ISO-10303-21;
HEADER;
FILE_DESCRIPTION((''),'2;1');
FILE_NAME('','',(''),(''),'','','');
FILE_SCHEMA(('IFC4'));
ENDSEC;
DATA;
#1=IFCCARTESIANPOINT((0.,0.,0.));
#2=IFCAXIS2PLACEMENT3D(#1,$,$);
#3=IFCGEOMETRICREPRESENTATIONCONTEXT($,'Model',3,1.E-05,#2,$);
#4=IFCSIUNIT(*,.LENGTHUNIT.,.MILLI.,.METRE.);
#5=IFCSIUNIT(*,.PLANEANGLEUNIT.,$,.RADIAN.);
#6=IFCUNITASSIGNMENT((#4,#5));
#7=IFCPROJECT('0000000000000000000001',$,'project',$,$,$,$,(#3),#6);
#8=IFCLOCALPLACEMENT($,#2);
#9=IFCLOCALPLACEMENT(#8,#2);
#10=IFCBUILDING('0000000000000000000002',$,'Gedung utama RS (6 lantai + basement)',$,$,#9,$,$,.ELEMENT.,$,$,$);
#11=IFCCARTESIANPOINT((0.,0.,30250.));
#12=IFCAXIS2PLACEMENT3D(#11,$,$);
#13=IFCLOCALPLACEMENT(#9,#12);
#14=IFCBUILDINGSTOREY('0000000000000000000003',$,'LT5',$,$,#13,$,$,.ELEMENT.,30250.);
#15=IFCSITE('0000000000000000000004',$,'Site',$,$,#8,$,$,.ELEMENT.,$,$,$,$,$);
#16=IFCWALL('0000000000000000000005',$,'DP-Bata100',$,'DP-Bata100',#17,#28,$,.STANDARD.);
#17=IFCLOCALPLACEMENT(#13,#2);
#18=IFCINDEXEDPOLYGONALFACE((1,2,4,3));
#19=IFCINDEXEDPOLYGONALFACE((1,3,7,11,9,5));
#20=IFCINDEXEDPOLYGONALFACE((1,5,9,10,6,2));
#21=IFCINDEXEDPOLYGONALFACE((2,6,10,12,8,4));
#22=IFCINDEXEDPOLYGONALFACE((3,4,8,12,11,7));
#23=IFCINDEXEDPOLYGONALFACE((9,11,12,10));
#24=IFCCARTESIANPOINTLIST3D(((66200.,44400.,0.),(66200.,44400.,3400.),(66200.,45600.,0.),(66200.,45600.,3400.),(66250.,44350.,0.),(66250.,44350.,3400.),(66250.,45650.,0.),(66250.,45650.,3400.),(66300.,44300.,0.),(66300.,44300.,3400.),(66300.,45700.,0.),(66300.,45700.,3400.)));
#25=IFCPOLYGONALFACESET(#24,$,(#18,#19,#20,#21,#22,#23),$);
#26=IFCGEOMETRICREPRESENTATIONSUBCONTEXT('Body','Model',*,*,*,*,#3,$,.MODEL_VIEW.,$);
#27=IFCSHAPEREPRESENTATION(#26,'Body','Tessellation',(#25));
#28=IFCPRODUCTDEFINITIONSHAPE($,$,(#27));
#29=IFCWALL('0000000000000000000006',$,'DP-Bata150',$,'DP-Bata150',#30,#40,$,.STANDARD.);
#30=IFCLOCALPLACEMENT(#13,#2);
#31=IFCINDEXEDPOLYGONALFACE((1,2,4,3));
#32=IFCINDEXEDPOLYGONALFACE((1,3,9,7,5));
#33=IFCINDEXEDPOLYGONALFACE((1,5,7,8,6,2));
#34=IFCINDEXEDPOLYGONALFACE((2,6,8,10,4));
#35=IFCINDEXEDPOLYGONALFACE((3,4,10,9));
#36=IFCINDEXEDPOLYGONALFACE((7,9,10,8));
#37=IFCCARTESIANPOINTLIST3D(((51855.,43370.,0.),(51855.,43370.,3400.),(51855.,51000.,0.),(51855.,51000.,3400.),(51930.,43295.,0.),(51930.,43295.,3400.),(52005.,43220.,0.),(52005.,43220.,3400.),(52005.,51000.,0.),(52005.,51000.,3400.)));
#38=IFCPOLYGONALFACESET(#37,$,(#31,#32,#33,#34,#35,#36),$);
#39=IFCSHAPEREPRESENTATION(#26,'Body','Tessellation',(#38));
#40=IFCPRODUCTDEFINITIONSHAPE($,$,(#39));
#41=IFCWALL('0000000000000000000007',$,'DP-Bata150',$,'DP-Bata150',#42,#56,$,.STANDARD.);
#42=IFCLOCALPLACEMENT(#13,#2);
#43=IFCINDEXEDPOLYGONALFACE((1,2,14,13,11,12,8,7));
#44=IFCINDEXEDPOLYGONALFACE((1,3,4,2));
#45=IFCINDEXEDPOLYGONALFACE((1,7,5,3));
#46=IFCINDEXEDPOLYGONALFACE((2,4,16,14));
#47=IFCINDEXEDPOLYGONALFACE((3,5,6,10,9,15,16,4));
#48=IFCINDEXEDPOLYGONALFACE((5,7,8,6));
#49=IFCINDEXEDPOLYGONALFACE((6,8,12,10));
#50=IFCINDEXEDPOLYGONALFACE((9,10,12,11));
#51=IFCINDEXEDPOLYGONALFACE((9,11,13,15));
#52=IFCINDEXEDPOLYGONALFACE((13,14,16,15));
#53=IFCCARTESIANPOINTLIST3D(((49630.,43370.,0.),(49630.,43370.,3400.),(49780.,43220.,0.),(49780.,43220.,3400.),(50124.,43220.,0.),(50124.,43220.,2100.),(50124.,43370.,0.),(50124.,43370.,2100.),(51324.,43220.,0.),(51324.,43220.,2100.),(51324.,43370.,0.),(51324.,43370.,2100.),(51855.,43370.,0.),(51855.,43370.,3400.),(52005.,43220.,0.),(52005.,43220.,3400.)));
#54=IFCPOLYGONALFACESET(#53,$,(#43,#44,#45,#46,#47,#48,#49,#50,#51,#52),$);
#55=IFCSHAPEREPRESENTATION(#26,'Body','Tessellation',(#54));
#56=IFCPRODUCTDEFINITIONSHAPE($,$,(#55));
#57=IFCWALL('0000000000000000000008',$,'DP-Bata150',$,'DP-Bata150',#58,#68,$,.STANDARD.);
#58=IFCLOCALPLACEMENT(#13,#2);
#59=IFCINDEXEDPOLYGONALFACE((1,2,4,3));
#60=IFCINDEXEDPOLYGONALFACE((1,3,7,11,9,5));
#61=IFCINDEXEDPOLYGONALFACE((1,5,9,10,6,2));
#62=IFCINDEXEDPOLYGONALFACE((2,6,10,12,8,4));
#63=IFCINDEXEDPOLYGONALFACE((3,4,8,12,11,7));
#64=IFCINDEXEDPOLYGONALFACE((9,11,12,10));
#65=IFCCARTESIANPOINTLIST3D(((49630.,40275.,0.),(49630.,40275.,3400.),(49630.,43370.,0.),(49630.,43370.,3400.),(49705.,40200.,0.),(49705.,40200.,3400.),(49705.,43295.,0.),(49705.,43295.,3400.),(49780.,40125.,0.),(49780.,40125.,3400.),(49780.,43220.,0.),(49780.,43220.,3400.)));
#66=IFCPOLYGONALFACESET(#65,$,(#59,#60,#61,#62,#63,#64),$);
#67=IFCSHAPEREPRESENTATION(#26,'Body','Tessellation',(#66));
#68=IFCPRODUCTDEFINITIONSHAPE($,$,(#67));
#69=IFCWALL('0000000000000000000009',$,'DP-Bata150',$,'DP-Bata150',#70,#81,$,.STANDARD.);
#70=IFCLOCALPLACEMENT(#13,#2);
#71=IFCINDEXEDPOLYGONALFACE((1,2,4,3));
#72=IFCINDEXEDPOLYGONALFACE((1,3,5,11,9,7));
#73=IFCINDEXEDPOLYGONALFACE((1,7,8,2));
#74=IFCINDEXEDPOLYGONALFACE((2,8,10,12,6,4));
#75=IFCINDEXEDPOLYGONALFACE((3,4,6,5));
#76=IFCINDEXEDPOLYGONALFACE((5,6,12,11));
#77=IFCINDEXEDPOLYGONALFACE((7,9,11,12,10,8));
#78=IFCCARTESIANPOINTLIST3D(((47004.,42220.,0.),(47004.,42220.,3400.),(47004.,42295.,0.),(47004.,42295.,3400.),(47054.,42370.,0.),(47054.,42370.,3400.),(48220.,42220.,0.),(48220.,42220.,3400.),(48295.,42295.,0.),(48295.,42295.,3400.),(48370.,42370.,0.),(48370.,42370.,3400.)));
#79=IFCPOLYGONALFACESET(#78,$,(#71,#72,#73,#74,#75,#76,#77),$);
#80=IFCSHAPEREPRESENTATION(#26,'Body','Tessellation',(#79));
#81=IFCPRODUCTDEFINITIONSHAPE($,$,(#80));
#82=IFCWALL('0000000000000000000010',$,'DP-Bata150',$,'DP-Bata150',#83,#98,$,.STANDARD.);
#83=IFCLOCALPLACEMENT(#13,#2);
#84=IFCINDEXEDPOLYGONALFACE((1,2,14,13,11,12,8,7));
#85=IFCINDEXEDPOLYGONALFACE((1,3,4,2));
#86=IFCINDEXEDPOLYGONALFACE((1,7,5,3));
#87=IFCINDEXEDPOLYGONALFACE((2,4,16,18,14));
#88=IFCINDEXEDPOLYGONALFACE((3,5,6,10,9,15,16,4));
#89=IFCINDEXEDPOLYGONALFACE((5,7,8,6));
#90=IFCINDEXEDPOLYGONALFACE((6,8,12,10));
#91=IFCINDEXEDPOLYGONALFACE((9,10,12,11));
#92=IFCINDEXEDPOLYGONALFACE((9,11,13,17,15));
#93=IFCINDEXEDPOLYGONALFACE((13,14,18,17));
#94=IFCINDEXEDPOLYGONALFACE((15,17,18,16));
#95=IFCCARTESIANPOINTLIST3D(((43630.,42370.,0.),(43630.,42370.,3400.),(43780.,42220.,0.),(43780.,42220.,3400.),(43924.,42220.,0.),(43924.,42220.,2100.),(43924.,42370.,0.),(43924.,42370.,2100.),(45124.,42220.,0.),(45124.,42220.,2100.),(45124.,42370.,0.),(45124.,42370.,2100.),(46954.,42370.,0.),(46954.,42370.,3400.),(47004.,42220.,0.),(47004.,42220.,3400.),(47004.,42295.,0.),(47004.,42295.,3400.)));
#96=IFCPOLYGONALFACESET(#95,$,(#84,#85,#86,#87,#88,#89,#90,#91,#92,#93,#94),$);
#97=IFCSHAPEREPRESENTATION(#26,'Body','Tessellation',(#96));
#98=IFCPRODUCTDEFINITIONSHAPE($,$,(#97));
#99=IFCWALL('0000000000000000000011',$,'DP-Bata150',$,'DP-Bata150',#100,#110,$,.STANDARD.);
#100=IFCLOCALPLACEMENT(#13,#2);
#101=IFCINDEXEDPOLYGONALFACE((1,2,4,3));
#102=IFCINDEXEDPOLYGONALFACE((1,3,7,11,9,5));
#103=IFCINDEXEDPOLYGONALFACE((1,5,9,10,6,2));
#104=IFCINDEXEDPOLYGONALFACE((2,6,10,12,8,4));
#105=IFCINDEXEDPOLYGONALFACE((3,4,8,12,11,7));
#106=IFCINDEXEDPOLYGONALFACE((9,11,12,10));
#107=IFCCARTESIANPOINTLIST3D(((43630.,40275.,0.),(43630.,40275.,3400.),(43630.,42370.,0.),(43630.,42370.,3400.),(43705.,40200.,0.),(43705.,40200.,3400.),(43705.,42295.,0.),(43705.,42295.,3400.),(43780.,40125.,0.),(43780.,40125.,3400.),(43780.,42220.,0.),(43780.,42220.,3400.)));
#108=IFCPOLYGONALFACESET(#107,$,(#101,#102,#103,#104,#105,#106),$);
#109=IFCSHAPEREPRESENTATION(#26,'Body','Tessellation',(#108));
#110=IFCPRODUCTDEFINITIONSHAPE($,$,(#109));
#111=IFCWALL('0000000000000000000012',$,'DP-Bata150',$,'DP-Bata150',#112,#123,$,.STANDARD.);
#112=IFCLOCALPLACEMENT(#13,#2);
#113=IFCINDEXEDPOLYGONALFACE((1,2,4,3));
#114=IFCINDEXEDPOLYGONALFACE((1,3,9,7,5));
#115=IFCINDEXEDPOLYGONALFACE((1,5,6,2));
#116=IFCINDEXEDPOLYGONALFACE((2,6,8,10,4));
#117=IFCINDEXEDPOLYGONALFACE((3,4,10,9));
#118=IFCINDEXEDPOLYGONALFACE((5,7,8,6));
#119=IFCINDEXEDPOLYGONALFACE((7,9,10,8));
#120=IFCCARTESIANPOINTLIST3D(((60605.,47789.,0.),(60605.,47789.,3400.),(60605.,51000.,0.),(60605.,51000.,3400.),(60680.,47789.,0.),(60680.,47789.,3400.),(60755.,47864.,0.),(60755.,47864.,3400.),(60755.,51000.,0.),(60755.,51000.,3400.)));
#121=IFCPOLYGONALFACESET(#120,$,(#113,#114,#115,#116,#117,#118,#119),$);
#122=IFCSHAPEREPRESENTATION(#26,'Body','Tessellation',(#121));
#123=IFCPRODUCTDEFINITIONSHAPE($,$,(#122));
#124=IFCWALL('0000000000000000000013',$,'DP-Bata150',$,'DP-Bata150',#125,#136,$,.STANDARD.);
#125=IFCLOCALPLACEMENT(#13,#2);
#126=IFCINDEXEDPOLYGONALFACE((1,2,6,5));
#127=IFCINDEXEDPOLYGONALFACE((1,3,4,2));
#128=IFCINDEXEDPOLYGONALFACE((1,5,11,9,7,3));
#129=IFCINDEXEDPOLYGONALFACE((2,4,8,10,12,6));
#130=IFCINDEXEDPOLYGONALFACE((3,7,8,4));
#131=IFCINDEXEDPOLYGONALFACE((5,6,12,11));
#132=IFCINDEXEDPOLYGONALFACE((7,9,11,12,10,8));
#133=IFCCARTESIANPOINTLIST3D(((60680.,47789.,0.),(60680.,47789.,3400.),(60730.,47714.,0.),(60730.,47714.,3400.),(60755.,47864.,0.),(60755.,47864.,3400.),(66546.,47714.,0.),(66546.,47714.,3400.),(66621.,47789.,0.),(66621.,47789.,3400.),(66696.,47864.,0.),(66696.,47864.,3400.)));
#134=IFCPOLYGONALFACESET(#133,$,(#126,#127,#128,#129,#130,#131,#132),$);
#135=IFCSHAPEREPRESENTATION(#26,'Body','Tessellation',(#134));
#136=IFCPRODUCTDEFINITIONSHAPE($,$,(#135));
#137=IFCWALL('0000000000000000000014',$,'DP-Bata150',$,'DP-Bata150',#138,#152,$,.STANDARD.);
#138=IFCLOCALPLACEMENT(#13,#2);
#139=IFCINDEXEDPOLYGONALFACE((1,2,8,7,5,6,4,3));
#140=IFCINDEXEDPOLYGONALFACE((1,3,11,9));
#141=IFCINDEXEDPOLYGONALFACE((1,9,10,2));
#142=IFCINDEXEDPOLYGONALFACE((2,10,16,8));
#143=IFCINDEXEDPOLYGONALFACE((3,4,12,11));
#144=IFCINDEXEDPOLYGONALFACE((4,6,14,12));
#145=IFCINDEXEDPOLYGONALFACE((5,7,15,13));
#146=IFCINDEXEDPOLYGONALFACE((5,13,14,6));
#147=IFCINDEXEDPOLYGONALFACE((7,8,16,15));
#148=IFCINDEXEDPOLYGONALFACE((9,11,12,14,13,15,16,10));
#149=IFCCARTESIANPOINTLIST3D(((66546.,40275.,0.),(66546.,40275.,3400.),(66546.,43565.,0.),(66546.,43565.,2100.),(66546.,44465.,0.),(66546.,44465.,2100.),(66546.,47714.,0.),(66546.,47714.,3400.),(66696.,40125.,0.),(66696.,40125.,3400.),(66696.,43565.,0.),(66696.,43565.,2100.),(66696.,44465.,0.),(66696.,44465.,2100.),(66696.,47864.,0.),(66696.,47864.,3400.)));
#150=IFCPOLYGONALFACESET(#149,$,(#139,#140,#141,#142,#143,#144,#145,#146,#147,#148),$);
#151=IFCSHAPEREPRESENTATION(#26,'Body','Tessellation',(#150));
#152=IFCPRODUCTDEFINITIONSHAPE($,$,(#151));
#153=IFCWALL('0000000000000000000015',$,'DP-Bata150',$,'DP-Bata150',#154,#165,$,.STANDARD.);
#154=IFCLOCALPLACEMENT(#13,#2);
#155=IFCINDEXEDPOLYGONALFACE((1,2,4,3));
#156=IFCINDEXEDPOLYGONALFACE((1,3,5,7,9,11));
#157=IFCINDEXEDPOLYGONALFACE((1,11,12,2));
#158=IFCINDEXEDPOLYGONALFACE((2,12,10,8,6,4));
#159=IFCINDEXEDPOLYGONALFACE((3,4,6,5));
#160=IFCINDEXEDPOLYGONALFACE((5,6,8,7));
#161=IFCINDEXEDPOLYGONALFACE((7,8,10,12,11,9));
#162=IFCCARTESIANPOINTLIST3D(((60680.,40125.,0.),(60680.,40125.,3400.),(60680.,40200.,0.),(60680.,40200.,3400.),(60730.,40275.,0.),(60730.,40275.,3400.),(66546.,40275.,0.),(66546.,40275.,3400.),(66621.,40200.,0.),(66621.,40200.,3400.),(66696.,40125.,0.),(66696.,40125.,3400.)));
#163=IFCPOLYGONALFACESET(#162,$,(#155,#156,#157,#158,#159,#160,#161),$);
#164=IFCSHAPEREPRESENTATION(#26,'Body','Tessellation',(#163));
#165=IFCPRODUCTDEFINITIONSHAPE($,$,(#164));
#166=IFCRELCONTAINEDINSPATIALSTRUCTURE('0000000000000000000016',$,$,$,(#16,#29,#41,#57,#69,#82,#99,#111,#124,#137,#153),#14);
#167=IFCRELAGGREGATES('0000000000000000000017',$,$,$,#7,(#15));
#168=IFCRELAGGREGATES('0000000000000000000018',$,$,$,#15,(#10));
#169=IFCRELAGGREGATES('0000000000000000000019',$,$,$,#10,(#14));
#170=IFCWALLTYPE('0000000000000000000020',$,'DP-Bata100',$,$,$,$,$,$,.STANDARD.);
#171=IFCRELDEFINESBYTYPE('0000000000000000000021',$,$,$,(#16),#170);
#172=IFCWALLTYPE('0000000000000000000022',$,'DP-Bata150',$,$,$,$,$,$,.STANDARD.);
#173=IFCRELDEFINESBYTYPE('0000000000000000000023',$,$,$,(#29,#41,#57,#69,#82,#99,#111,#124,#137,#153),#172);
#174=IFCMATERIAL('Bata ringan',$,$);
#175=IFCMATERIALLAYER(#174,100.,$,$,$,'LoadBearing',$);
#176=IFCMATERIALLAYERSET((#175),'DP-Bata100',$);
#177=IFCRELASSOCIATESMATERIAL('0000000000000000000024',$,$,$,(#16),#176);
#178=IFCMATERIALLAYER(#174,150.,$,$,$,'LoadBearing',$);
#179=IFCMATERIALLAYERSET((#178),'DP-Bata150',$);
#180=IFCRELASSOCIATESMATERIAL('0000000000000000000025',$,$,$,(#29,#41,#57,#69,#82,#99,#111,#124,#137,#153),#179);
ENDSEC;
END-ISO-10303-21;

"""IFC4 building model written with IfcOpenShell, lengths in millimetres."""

from ifc_helpers import new_model, si_unit, frame, frame_2d, origin, place, context, subcontext, project, spatial, polyline, rectangle, outline, extrude, material, layer, layer_set, layer_usage, type_object, element, save


model = new_model("IFC4")

# Units and contexts
model_context = context("Model", 3, precision=1e-05, world=origin())
body_context = subcontext(model_context, "Body", "Model", "MODEL_VIEW")
ifc_project = project(units=[si_unit("LENGTHUNIT", "METRE", prefix="MILLI"), si_unit("PLANEANGLEUNIT", "RADIAN")], contexts=[model_context])

# Site, building, storey
site_placement = place(None, origin())
site = spatial("IfcSite", under=ifc_project, at=site_placement, Name="Site", CompositionType="ELEMENT")
building_placement = place(site_placement, origin())
building = spatial("IfcBuilding", under=site, at=building_placement, Name="Gedung utama RS (6 lantai + basement)", CompositionType="ELEMENT")
storey_placement = place(building_placement, frame((0.0, 0.0, 30250.0)))
storey = spatial("IfcBuildingStorey", under=building, at=storey_placement, Name="LT5", CompositionType="ELEMENT", Elevation=30250.0)

# Walls
ifc_material_1 = material(Name="Bata ringan")
ifc_layer_1 = layer(ifc_material_1, 100.0, Category="LoadBearing")
ifc_layer_set_1 = layer_set([ifc_layer_1], Name="DP-Bata100")
ifc_layer_usage_1 = layer_usage(ifc_layer_set_1, "AXIS2", "NEGATIVE", 50.0)
wall_type_1 = type_object("IfcWallType", Name="DP-Bata100", PredefinedType="STANDARD")
wall_1_placement = place(storey_placement, frame((66250.0, 45650.0, 0.0), z_axis=(0.0, 0.0, 1.0), x_axis=(0.0, -1.0, 0.0)))
element("IfcWall", 1, at=wall_1_placement, inside=storey, type_object=wall_type_1, material=ifc_layer_usage_1, Name="DP-Bata100", ObjectType="DP-Bata100", PredefinedType="STANDARD", context=body_context, shape_type="SweptSolid", body=[
    extrude(outline(polyline([(50.0, -50.0), (0.0, 0.0), (-50.0, 50.0), (1350.0, 50.0), (1300.0, 0.0), (1250.0, -50.0), (50.0, -50.0)])), origin(), (0.0, 0.0, 1.0), 3400.0),
])
ifc_layer_2 = layer(ifc_material_1, 150.0, Category="LoadBearing")
ifc_layer_set_2 = layer_set([ifc_layer_2], Name="DP-Bata150")
ifc_layer_usage_2 = layer_usage(ifc_layer_set_2, "AXIS2", "NEGATIVE", 75.0)
wall_type_2 = type_object("IfcWallType", Name="DP-Bata150", PredefinedType="STANDARD")
wall_2_placement = place(storey_placement, frame((51930.0, 51000.0, 0.0), z_axis=(0.0, 0.0, 1.0), x_axis=(0.0, -1.0, 0.0)))
element("IfcWall", 2, at=wall_2_placement, inside=storey, type_object=wall_type_2, material=ifc_layer_usage_2, Name="DP-Bata150", ObjectType="DP-Bata150", PredefinedType="STANDARD", context=body_context, shape_type="SweptSolid", body=[
    extrude(outline(polyline([(0.0, -75.0), (0.0, 75.0), (7780.0, 75.0), (7705.0, 0.0), (7630.0, -75.0), (0.0, -75.0)])), origin(), (0.0, 0.0, 1.0), 3400.0),
])

# Wall, opening
wall_3_placement = place(storey_placement, frame((51930.0, 43295.0, 0.0), z_axis=(0.0, 0.0, 1.0), x_axis=(-1.0, 0.0, 0.0)))
wall_3 = element("IfcWall", 3, at=wall_3_placement, inside=storey, type_object=wall_type_2, material=ifc_layer_usage_2, Name="DP-Bata150", ObjectType="DP-Bata150", PredefinedType="STANDARD", context=body_context, shape_type="SweptSolid", body=[
    extrude(outline(polyline([(75.0, -75.0), (0.0, 0.0), (-75.0, 75.0), (2150.0, 75.0), (2225.0, 0.0), (2300.0, -75.0), (75.0, -75.0)])), origin(), (0.0, 0.0, 1.0), 3400.0),
])
opening_1_placement = place(wall_3_placement, frame((606.0, 0.0, 0.0), z_axis=(0.0, 0.0, 1.0), x_axis=(1.0, 0.0, 0.0)))
element("IfcOpeningElement", 4, at=opening_1_placement, cuts=wall_3, PredefinedType="OPENING", context=body_context, shape_type="SweptSolid", body=[
    extrude(rectangle(XDim=1200.0, YDim=170.0, at=frame_2d((600.0, 0.0))), origin(), (0.0, 0.0, 1.0), 2100.0),
])

# Walls
wall_4_placement = place(storey_placement, frame((49705.0, 43295.0, 0.0), z_axis=(0.0, 0.0, 1.0), x_axis=(0.0, -1.0, 0.0)))
element("IfcWall", 5, at=wall_4_placement, inside=storey, type_object=wall_type_2, material=ifc_layer_usage_2, Name="DP-Bata150", ObjectType="DP-Bata150", PredefinedType="STANDARD", context=body_context, shape_type="SweptSolid", body=[
    extrude(outline(polyline([(-75.0, -75.0), (0.0, 0.0), (75.0, 75.0), (3170.0, 75.0), (3095.0, 0.0), (3020.0, -75.0), (-75.0, -75.0)])), origin(), (0.0, 0.0, 1.0), 3400.0),
])
wall_5_placement = place(storey_placement, frame((48295.0, 42295.0, 0.0), z_axis=(0.0, 0.0, 1.0), x_axis=(-1.0, 0.0, 0.0)))
element("IfcWall", 6, at=wall_5_placement, inside=storey, type_object=wall_type_2, material=ifc_layer_usage_2, Name="DP-Bata150", ObjectType="DP-Bata150", PredefinedType="STANDARD", context=body_context, shape_type="SweptSolid", body=[
    extrude(outline(polyline([(-75.0, -75.0), (0.0, 0.0), (75.0, 75.0), (1291.0, 75.0), (1291.0, 0.0), (1241.0, -75.0), (-75.0, -75.0)])), origin(), (0.0, 0.0, 1.0), 3400.0),
])

# Wall, opening
wall_6_placement = place(storey_placement, frame((47004.0, 42295.0, 0.0), z_axis=(0.0, 0.0, 1.0), x_axis=(-1.0, 0.0, 0.0)))
wall_6 = element("IfcWall", 7, at=wall_6_placement, inside=storey, type_object=wall_type_2, material=ifc_layer_usage_2, Name="DP-Bata150", ObjectType="DP-Bata150", PredefinedType="STANDARD", context=body_context, shape_type="SweptSolid", body=[
    extrude(outline(polyline([(50.0, -75.0), (0.0, 0.0), (0.0, 75.0), (3224.0, 75.0), (3299.0, 0.0), (3374.0, -75.0), (50.0, -75.0)])), origin(), (0.0, 0.0, 1.0), 3400.0),
])
opening_2_placement = place(wall_6_placement, frame((1880.0, 0.0, 0.0), z_axis=(0.0, 0.0, 1.0), x_axis=(1.0, 0.0, 0.0)))
element("IfcOpeningElement", 8, at=opening_2_placement, cuts=wall_6, PredefinedType="OPENING", context=body_context, shape_type="SweptSolid", body=[
    extrude(rectangle(XDim=1200.0, YDim=170.0, at=frame_2d((600.0, 0.0))), origin(), (0.0, 0.0, 1.0), 2100.0),
])

# Walls
wall_7_placement = place(storey_placement, frame((43705.0, 42295.0, 0.0), z_axis=(0.0, 0.0, 1.0), x_axis=(0.0, -1.0, 0.0)))
element("IfcWall", 9, at=wall_7_placement, inside=storey, type_object=wall_type_2, material=ifc_layer_usage_2, Name="DP-Bata150", ObjectType="DP-Bata150", PredefinedType="STANDARD", context=body_context, shape_type="SweptSolid", body=[
    extrude(outline(polyline([(-75.0, -75.0), (0.0, 0.0), (75.0, 75.0), (2170.0, 75.0), (2095.0, 0.0), (2020.0, -75.0), (-75.0, -75.0)])), origin(), (0.0, 0.0, 1.0), 3400.0),
])
wall_8_placement = place(storey_placement, frame((60680.0, 51000.0, 0.0), z_axis=(0.0, 0.0, 1.0), x_axis=(0.0, -1.0, 0.0)))
element("IfcWall", 10, at=wall_8_placement, inside=storey, type_object=wall_type_2, material=ifc_layer_usage_2, Name="DP-Bata150", ObjectType="DP-Bata150", PredefinedType="STANDARD", context=body_context, shape_type="SweptSolid", body=[
    extrude(outline(polyline([(0.0, -75.0), (0.0, 75.0), (3136.0, 75.0), (3211.0, 0.0), (3211.0, -75.0), (0.0, -75.0)])), origin(), (0.0, 0.0, 1.0), 3400.0),
])
wall_9_placement = place(storey_placement, frame((60680.0, 47789.0, 0.0), z_axis=(0.0, 0.0, 1.0), x_axis=(1.0, 0.0, 0.0)))
element("IfcWall", 11, at=wall_9_placement, inside=storey, type_object=wall_type_2, material=ifc_layer_usage_2, Name="DP-Bata150", ObjectType="DP-Bata150", PredefinedType="STANDARD", context=body_context, shape_type="SweptSolid", body=[
    extrude(outline(polyline([(50.0, -75.0), (0.0, 0.0), (75.0, 75.0), (6016.0, 75.0), (5941.0, 0.0), (5866.0, -75.0), (50.0, -75.0)])), origin(), (0.0, 0.0, 1.0), 3400.0),
])

# Wall, opening
wall_10_placement = place(storey_placement, frame((66621.0, 47789.0, 0.0), z_axis=(0.0, 0.0, 1.0), x_axis=(0.0, -1.0, 0.0)))
wall_10 = element("IfcWall", 12, at=wall_10_placement, inside=storey, type_object=wall_type_2, material=ifc_layer_usage_2, Name="DP-Bata150", ObjectType="DP-Bata150", PredefinedType="STANDARD", context=body_context, shape_type="SweptSolid", body=[
    extrude(outline(polyline([(75.0, -75.0), (0.0, 0.0), (-75.0, 75.0), (7664.0, 75.0), (7589.0, 0.0), (7514.0, -75.0), (75.0, -75.0)])), origin(), (0.0, 0.0, 1.0), 3400.0),
])
opening_3_placement = place(wall_10_placement, frame((3324.0, 0.0, 0.0), z_axis=(0.0, 0.0, 1.0), x_axis=(1.0, 0.0, 0.0)))
element("IfcOpeningElement", 13, at=opening_3_placement, cuts=wall_10, PredefinedType="OPENING", context=body_context, shape_type="SweptSolid", body=[
    extrude(rectangle(XDim=900.0, YDim=170.0, at=frame_2d((450.0, 0.0))), origin(), (0.0, 0.0, 1.0), 2100.0),
])

# Wall
wall_11_placement = place(storey_placement, frame((66621.0, 40200.0, 0.0), z_axis=(0.0, 0.0, 1.0), x_axis=(-1.0, 0.0, 0.0)))
element("IfcWall", 14, at=wall_11_placement, inside=storey, type_object=wall_type_2, material=ifc_layer_usage_2, Name="DP-Bata150", ObjectType="DP-Bata150", PredefinedType="STANDARD", context=body_context, shape_type="SweptSolid", body=[
    extrude(outline(polyline([(75.0, -75.0), (0.0, 0.0), (-75.0, 75.0), (5941.0, 75.0), (5941.0, 0.0), (5891.0, -75.0), (75.0, -75.0)])), origin(), (0.0, 0.0, 1.0), 3400.0),
])

save(model, "model.ifc")
